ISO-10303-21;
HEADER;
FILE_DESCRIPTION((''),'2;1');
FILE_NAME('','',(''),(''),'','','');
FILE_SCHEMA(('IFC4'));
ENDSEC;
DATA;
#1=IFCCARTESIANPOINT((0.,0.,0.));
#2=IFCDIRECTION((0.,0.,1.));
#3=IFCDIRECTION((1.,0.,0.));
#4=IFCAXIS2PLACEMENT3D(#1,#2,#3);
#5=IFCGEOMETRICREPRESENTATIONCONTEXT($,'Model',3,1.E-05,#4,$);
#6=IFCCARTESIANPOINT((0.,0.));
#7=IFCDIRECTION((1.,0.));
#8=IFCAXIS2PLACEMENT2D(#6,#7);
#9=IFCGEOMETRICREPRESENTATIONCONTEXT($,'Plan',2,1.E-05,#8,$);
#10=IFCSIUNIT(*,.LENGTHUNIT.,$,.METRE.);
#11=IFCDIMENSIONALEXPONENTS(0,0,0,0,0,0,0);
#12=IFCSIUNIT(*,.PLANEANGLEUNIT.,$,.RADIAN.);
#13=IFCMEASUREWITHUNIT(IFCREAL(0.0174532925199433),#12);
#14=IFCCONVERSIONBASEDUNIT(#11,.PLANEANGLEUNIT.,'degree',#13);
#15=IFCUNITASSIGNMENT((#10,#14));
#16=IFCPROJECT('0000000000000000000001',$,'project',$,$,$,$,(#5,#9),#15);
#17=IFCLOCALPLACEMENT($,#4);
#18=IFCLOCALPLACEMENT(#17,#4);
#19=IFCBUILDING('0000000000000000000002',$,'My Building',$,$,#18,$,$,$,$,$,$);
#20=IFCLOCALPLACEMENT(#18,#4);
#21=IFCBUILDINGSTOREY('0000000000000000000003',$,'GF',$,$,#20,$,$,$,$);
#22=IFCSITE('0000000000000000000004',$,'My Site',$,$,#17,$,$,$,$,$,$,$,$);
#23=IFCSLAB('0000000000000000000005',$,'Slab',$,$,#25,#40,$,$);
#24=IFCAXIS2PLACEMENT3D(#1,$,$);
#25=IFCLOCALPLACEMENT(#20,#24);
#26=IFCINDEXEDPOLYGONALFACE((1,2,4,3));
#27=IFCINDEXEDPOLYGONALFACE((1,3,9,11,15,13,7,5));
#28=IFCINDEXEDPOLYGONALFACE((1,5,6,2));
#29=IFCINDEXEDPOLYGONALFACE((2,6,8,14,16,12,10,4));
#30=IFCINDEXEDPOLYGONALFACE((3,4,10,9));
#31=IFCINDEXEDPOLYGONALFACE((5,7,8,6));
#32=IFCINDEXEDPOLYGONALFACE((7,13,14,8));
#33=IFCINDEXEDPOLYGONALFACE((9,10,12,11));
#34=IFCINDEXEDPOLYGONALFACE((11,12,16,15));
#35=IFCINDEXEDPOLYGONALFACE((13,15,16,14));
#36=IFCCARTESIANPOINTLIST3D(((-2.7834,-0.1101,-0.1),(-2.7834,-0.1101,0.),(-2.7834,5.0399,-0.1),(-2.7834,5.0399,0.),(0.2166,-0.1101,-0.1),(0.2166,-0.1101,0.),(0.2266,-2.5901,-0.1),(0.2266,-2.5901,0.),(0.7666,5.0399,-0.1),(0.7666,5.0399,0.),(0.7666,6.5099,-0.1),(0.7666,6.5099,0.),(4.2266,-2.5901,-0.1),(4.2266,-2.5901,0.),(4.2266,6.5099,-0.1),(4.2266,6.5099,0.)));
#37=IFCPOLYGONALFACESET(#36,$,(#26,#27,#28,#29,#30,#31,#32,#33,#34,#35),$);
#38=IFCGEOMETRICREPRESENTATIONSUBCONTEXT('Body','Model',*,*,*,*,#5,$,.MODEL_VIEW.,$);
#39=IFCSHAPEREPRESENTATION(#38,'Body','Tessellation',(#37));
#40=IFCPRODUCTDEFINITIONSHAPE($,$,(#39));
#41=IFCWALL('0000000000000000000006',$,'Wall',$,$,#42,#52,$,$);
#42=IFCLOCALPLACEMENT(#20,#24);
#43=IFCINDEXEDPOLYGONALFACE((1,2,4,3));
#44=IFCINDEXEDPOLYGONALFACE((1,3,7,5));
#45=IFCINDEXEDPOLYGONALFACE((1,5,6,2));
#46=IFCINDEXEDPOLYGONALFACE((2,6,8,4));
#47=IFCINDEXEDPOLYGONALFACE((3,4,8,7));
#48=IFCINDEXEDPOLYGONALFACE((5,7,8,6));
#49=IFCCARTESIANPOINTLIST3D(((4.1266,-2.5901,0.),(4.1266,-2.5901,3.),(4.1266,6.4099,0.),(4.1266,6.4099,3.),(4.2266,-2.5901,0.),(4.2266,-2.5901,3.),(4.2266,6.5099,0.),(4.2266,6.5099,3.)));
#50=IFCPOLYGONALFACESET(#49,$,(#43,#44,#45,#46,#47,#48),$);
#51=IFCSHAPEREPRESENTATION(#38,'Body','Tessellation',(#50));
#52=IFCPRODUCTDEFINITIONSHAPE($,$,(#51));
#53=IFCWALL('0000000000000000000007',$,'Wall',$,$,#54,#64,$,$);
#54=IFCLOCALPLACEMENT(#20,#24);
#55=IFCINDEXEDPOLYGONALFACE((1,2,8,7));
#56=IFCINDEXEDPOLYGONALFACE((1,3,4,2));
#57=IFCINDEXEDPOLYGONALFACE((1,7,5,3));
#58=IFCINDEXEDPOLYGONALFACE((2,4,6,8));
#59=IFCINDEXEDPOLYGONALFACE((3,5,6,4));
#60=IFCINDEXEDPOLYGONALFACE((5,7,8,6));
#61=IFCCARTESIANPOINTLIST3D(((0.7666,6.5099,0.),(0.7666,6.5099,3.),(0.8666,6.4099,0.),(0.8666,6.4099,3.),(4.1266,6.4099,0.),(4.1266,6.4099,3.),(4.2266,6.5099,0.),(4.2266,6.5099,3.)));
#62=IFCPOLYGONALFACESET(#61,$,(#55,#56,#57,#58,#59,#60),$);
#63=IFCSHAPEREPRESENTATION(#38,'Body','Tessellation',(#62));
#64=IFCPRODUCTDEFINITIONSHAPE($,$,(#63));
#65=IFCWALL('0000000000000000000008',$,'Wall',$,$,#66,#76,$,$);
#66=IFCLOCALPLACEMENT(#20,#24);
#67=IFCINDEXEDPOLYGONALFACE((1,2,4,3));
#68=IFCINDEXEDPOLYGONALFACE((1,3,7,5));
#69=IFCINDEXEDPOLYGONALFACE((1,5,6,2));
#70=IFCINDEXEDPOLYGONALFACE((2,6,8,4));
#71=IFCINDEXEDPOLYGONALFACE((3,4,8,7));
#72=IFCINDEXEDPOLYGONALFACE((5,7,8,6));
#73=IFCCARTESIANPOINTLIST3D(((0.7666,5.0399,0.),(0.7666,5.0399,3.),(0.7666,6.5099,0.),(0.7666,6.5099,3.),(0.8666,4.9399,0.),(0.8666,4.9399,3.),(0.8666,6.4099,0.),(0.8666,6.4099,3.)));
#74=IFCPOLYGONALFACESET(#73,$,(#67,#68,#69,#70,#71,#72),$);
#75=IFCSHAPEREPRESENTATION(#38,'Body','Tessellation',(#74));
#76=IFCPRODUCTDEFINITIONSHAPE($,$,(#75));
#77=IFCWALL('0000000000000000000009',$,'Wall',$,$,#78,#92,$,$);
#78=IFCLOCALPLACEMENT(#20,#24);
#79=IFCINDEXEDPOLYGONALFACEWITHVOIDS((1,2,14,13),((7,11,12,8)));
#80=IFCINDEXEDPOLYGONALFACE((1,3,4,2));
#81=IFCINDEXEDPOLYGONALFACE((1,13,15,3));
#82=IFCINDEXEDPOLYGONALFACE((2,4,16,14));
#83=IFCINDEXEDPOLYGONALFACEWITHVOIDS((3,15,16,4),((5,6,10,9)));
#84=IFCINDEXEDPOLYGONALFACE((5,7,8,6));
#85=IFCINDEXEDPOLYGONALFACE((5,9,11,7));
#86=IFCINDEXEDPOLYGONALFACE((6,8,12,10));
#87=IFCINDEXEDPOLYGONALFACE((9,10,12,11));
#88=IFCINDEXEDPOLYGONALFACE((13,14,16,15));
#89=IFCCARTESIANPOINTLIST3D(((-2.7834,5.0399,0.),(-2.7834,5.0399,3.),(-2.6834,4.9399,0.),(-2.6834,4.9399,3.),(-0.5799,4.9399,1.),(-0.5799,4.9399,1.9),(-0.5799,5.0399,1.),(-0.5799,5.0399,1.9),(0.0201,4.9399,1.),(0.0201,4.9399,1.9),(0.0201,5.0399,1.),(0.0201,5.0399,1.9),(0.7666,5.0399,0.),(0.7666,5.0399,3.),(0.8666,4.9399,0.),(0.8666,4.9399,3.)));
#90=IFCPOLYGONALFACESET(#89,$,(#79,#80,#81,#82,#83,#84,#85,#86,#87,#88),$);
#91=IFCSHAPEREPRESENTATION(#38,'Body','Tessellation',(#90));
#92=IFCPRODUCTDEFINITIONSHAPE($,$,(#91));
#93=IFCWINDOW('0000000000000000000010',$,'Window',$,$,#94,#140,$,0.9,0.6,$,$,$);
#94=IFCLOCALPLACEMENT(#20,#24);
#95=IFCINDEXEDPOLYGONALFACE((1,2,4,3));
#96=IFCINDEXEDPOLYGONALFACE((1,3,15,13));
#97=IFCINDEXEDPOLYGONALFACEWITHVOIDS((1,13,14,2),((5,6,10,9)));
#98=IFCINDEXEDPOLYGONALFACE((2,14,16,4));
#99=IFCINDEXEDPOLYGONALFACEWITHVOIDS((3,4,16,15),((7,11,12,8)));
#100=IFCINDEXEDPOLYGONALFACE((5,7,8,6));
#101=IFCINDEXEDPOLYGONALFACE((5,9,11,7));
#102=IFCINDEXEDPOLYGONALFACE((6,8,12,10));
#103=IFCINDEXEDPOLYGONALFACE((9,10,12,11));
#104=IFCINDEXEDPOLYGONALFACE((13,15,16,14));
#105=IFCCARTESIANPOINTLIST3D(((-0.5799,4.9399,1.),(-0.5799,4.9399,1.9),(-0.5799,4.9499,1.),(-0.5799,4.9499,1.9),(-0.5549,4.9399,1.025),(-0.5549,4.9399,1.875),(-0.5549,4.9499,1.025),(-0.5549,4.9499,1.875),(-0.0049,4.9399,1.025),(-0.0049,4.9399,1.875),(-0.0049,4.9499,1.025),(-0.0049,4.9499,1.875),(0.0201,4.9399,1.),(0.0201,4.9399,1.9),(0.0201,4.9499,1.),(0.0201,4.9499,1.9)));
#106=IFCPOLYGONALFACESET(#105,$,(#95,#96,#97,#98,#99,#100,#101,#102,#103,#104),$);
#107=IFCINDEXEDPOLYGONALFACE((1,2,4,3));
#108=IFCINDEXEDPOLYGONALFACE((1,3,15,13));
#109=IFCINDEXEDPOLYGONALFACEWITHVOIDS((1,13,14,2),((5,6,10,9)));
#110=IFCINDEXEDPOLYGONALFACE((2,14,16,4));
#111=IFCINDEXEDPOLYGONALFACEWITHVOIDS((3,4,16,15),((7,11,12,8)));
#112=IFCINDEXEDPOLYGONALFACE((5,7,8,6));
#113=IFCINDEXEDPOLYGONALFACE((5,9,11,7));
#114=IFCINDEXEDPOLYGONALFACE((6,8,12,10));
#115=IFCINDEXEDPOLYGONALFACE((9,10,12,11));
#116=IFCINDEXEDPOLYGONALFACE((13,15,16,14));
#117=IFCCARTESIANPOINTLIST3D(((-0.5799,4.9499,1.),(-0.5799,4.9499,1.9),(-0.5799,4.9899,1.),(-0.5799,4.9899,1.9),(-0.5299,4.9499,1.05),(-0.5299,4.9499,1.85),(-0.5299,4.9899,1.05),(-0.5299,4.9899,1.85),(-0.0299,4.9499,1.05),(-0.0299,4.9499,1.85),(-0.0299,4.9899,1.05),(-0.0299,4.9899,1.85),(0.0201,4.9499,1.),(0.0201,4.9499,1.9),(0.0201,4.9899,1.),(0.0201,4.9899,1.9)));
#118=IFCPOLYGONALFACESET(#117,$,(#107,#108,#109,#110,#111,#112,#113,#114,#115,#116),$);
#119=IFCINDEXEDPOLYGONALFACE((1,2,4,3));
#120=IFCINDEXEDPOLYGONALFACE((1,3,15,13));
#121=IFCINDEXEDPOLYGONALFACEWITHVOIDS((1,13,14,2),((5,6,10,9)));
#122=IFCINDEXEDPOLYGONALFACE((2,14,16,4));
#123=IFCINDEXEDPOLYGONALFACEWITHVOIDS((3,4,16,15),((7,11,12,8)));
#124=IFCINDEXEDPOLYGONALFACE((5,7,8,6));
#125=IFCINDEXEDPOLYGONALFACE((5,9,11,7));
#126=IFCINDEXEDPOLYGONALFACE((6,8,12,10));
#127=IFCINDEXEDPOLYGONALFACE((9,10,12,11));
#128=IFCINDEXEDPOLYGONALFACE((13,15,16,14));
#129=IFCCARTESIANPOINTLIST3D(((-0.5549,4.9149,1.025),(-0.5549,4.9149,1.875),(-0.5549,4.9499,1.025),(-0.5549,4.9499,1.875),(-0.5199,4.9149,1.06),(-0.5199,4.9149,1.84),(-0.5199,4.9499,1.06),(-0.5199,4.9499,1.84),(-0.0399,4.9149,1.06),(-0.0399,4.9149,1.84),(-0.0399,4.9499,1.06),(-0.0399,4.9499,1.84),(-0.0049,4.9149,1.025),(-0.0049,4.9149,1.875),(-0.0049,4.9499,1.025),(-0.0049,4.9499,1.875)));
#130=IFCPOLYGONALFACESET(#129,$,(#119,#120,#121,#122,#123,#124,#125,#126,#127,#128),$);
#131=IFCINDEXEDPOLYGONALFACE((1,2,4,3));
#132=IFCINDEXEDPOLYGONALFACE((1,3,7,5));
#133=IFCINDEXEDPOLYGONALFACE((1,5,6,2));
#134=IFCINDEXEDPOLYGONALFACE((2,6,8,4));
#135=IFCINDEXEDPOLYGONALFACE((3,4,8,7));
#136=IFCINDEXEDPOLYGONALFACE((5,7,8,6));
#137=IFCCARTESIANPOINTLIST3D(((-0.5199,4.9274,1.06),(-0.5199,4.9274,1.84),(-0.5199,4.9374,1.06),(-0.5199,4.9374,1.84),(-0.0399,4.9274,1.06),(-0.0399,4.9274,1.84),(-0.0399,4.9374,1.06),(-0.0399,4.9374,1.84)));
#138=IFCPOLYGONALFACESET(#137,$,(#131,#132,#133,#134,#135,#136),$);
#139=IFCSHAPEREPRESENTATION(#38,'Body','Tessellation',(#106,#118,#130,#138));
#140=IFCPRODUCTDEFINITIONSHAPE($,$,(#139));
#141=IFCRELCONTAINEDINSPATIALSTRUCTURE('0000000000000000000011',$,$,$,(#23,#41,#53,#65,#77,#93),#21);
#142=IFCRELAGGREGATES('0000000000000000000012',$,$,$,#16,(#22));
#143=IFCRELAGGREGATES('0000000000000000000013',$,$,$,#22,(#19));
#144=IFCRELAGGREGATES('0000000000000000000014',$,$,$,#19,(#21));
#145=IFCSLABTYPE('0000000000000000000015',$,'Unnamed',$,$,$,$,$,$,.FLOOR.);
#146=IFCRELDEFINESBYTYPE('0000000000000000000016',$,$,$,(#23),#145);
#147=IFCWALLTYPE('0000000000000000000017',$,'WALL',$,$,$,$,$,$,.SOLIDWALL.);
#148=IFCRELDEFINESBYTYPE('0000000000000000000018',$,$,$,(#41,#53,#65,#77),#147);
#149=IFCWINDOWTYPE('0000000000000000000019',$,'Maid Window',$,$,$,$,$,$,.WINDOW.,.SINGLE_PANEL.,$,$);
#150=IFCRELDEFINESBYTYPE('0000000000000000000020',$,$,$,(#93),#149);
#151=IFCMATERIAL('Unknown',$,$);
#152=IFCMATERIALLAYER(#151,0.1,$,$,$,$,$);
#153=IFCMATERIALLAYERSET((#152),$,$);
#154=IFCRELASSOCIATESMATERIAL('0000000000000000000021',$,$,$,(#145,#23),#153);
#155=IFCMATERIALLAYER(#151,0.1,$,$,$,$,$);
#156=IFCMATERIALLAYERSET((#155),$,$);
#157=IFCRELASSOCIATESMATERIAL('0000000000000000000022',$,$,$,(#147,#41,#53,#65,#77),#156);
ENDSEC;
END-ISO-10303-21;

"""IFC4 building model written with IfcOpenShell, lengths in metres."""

from ifc_helpers import new_model, entity, si_unit, converted_unit, frame, origin_with_axes, origin_2d_with_axis, place, context, subcontext, project, spatial, line, indexed_curve, outline, extrude, shape, source, transform, mapped, material, layer, layer_set, layer_usage, type_object, type_shapes, element, fill, save


model = new_model("IFC4")

# Units and contexts
model_context = context("Model", 3, precision=1e-05, world=origin_with_axes())
plan_context = context("Plan", 2, precision=1e-05, world=origin_2d_with_axis())
body_context_1 = subcontext(model_context, "Body", "Model", "MODEL_VIEW")
body_context_2 = subcontext(plan_context, "Body", "Plan", "PLAN_VIEW")
ifc_project = project(units=[si_unit("LENGTHUNIT", "METRE"), converted_unit("PLANEANGLEUNIT", "degree", entity("IfcReal", 0.0174532925199433), si_unit("PLANEANGLEUNIT", "RADIAN"), dimensions=[0, 0, 0, 0, 0, 0, 0])], contexts=[model_context, plan_context])

# Site, building, storey
site_placement = place(None, origin_with_axes())
site = spatial("IfcSite", under=ifc_project, at=site_placement, Name="My Site")
building_placement = place(site_placement, origin_with_axes())
building = spatial("IfcBuilding", under=site, at=building_placement, Name="My Building")
storey_placement = place(building_placement, origin_with_axes())
storey = spatial("IfcBuildingStorey", under=building, at=storey_placement, Name="GF")

# Slab
ifc_material = material(Name="Unknown")
ifc_layer_1 = layer(ifc_material, 0.1)
ifc_layer_set_1 = layer_set([ifc_layer_1])
ifc_layer_usage_1 = layer_usage(ifc_layer_set_1, "AXIS3", "POSITIVE", -0.1)
slab_type = type_object("IfcSlabType", Name="Unnamed", PredefinedType="FLOOR", material=ifc_layer_set_1)
slab_placement = place(storey_placement, frame((4.2266, -2.5901, 0.0), z_axis=(0.0, 0.0, 1.0), x_axis=(1.0, 0.0, 0.0)))
element("IfcSlab", 1, at=slab_placement, inside=storey, type_object=slab_type, material=ifc_layer_usage_1, Name="Slab", context=body_context_1, shape_type="SweptSolid", body=[
    extrude(outline(indexed_curve([(0.0, 0.0), (0.0, 9.1), (-3.46, 9.1), (-3.46, 7.63), (-7.01, 7.63), (-7.01, 2.48), (-4.01, 2.48), (-4.0, 0.0), (0.0, 0.0)])), frame((0.0, 0.0, -0.1), z_axis=(0.0, 0.0, 1.0), x_axis=(1.0, 0.0, 0.0)), (0.0, 0.0, 1.0), 0.1),
])

# Shared definitions
ifc_layer_2 = layer(ifc_material, 0.1)
ifc_layer_set_2 = layer_set([ifc_layer_2])
wall_type = type_object("IfcWallType", Name="WALL", PredefinedType="SOLIDWALL", material=ifc_layer_set_2)

# Walls
ifc_layer_usage_2 = layer_usage(ifc_layer_set_2, "AXIS2", "POSITIVE", 0.0)
wall_1_placement = place(storey_placement, frame((4.2266, -2.5901, 0.0), z_axis=(0.0, 0.0, 1.0), x_axis=(0.0, 1.0, 0.0)))
element("IfcWall", 2, at=wall_1_placement, inside=storey, type_object=wall_type, material=ifc_layer_usage_2, Name="Wall", context=body_context_1, shape_type="SweptSolid", body=[
    extrude(outline(indexed_curve([(0.0, 0.0), (0.0, 0.1), (9.0, 0.1), (9.1, 0.0)], segments=[line(1, 2, 3, 4, 1)])), origin_with_axes(), (0.0, 0.0, 1.0), 3.0),
])
ifc_layer_usage_3 = layer_usage(ifc_layer_set_2, "AXIS2", "POSITIVE", 0.0)
wall_2_placement = place(storey_placement, frame((4.2266, 6.5099, 0.0), z_axis=(0.0, 0.0, 1.0), x_axis=(-1.0, 0.0, 0.0)))
element("IfcWall", 3, at=wall_2_placement, inside=storey, type_object=wall_type, material=ifc_layer_usage_3, Name="Wall", context=body_context_1, shape_type="SweptSolid", body=[
    extrude(outline(indexed_curve([(0.0, 0.0), (0.1, 0.1), (3.36, 0.1), (3.46, 0.0)], segments=[line(1, 2, 3, 4, 1)])), origin_with_axes(), (0.0, 0.0, 1.0), 3.0),
])
ifc_layer_usage_4 = layer_usage(ifc_layer_set_2, "AXIS2", "POSITIVE", 0.0)
wall_3_placement = place(storey_placement, frame((0.7666, 6.5099, 0.0), z_axis=(0.0, 0.0, 1.0), x_axis=(0.0, -1.0, 0.0)))
element("IfcWall", 4, at=wall_3_placement, inside=storey, type_object=wall_type, material=ifc_layer_usage_4, Name="Wall", context=body_context_1, shape_type="SweptSolid", body=[
    extrude(outline(indexed_curve([(0.0, 0.0), (0.1, 0.1), (1.57, 0.1), (1.47, 0.0)], segments=[line(1, 2, 3, 4, 1)])), origin_with_axes(), (0.0, 0.0, 1.0), 3.0),
])

# Wall, opening, window
ifc_layer_usage_5 = layer_usage(ifc_layer_set_2, "AXIS2", "POSITIVE", 0.0)
wall_4_placement = place(storey_placement, frame((0.7666, 5.0399, 0.0), z_axis=(0.0, 0.0, 1.0), x_axis=(-1.0, 0.0, 0.0)))
wall_4 = element("IfcWall", 5, at=wall_4_placement, inside=storey, type_object=wall_type, material=ifc_layer_usage_5, Name="Wall", context=body_context_1, shape_type="SweptSolid", body=[
    extrude(outline(indexed_curve([(0.0, 0.0), (-0.1, 0.1), (3.45, 0.1), (3.55, 0.0)], segments=[line(1, 2, 3, 4, 1)])), origin_with_axes(), (0.0, 0.0, 1.0), 3.0),
])
shared_shape_1 = source(origin_with_axes(), body_context_1, "Body", "SweptSolid", [
    extrude(outline(indexed_curve([(0.0, 0.0), (0.6, 0.0), (0.6, 0.9), (0.0, 0.9)], segments=[line(1, 2, 3, 4, 1)])), frame((0.0, -0.6, 0.0), z_axis=(0.0, -1.0, 0.0), x_axis=(1.0, 0.0, 0.0)), (0.0, 0.0, -1.0), 1.2),
])
opening_1_placement = place(wall_4_placement, frame((0.7465, 0.0, 1.0), z_axis=(0.0, 0.0, 1.0), x_axis=(1.0, 0.0, 0.0)))
opening_1 = element("IfcOpeningElement", 6, at=opening_1_placement, cuts=wall_4, PredefinedType="OPENING", context=body_context_1, shape_type="MappedRepresentation", body=[
    mapped(shared_shape_1, transform((0.0, 0.0, 0.0), x_axis=(1.0, 0.0, 0.0), y_axis=(0.0, 1.0, 0.0), z_axis=(0.0, 0.0, 1.0), scale=1.0)),
])
window_type_1 = type_object("IfcWindowType", Name="Maid Window", PartitioningType="SINGLE_PANEL", PredefinedType="WINDOW")
shared_shape_2 = source(origin_with_axes(), body_context_1, "Body", "SweptSolid", [
    extrude(outline(indexed_curve([(0.0, 0.0), (0.6, 0.0), (0.6, 0.9), (0.0, 0.9)], segments=[line(1, 2, 3, 4, 1)]), holes=[indexed_curve([(0.025, 0.025), (0.575, 0.025), (0.575, 0.875), (0.025, 0.875)], segments=[line(1, 2, 3, 4, 1)])]), frame((0.0, 0.09, 0.0), z_axis=(0.0, -1.0, 0.0), x_axis=(1.0, 0.0, 0.0)), (0.0, 0.0, -1.0), 0.01),
    extrude(outline(indexed_curve([(0.0, 0.0), (0.6, 0.0), (0.6, 0.9), (0.0, 0.9)], segments=[line(1, 2, 3, 4, 1)]), holes=[indexed_curve([(0.05, 0.05), (0.55, 0.05), (0.55, 0.85), (0.05, 0.85)], segments=[line(1, 2, 3, 4, 1)])]), frame((0.0, 0.05, 0.0), z_axis=(0.0, -1.0, 0.0), x_axis=(1.0, 0.0, 0.0)), (0.0, 0.0, -1.0), 0.04),
    extrude(outline(indexed_curve([(0.0, 0.0), (0.55, 0.0), (0.55, 0.85), (0.0, 0.85)], segments=[line(1, 2, 3, 4, 1)]), holes=[indexed_curve([(0.035, 0.035), (0.515, 0.035), (0.515, 0.815), (0.035, 0.815)], segments=[line(1, 2, 3, 4, 1)])]), frame((0.025, 0.09, 0.025), z_axis=(0.0, -1.0, 0.0), x_axis=(1.0, 0.0, 0.0)), (0.0, 0.0, -1.0), 0.035),
    extrude(outline(indexed_curve([(0.035, 0.035), (0.515, 0.035), (0.515, 0.815), (0.035, 0.815)], segments=[line(1, 2, 3, 4, 1)])), frame((0.025, 0.1025, 0.025), z_axis=(0.0, -1.0, 0.0), x_axis=(1.0, 0.0, 0.0)), (0.0, 0.0, -1.0), 0.01),
])
shared_shape_3 = source(origin_with_axes(), body_context_2, "Body", "Curve2D", [
    entity("IfcIndexedPolyCurve", entity("IfcCartesianPointList2D", [[0.05, 0.05], [0.55, 0.05]])),
    entity("IfcIndexedPolyCurve", entity("IfcCartesianPointList2D", [[0.0, 0.1], [0.025, 0.1], [0.025, 0.09], [0.05, 0.09], [0.05, 0.05], [0.0, 0.05]]), [entity("IfcLineIndex", [1, 2, 3, 4, 5, 6, 1])]),
    entity("IfcIndexedPolyCurve", entity("IfcCartesianPointList2D", [[0.6, 0.1], [0.575, 0.1], [0.575, 0.09], [0.55, 0.09], [0.55, 0.05], [0.6, 0.05]]), [entity("IfcLineIndex", [1, 2, 3, 4, 5, 6, 1])]),
    entity("IfcIndexedPolyCurve", entity("IfcCartesianPointList2D", [[0.025, 0.09], [0.06, 0.09], [0.06, 0.125], [0.025, 0.125]]), [entity("IfcLineIndex", [1, 2, 3, 4, 1])]),
    entity("IfcIndexedPolyCurve", entity("IfcCartesianPointList2D", [[0.575, 0.09], [0.54, 0.09], [0.54, 0.125], [0.575, 0.125]]), [entity("IfcLineIndex", [1, 2, 3, 4, 1])]),
    entity("IfcIndexedPolyCurve", entity("IfcCartesianPointList2D", [[0.06, 0.09], [0.54, 0.09]])),
    entity("IfcIndexedPolyCurve", entity("IfcCartesianPointList2D", [[0.06, 0.125], [0.54, 0.125]])),
    entity("IfcIndexedPolyCurve", entity("IfcCartesianPointList2D", [[0.06, 0.1075], [0.54, 0.1075]])),
])
type_shapes(window_type_1, [shared_shape_2, shared_shape_3])
window_1_placement = place(opening_1_placement, frame((0.0, 0.0, 0.0), z_axis=(0.0, 0.0, 1.0), x_axis=(1.0, 0.0, 0.0)))
window_1 = element("IfcWindow", 7, at=window_1_placement, inside=storey, type_object=window_type_1, Name="Window", OverallHeight=0.9, OverallWidth=0.6, shapes=[
    shape(body_context_1, "Body", "MappedRepresentation", [mapped(shared_shape_2, transform((0.0, 0.0, 0.0), x_axis=(1.0, 0.0, 0.0), y_axis=(0.0, 1.0, 0.0), z_axis=(0.0, 0.0, 1.0), scale=1.0))]),
    shape(body_context_2, "Body", "MappedRepresentation", [mapped(shared_shape_3, transform((0.0, 0.0, 0.0), x_axis=(1.0, 0.0, 0.0), y_axis=(0.0, 1.0, 0.0), z_axis=(0.0, 0.0, 1.0), scale=1.0))]),
])
fill(opening_1, window_1)

save(model, "model.ifc")
